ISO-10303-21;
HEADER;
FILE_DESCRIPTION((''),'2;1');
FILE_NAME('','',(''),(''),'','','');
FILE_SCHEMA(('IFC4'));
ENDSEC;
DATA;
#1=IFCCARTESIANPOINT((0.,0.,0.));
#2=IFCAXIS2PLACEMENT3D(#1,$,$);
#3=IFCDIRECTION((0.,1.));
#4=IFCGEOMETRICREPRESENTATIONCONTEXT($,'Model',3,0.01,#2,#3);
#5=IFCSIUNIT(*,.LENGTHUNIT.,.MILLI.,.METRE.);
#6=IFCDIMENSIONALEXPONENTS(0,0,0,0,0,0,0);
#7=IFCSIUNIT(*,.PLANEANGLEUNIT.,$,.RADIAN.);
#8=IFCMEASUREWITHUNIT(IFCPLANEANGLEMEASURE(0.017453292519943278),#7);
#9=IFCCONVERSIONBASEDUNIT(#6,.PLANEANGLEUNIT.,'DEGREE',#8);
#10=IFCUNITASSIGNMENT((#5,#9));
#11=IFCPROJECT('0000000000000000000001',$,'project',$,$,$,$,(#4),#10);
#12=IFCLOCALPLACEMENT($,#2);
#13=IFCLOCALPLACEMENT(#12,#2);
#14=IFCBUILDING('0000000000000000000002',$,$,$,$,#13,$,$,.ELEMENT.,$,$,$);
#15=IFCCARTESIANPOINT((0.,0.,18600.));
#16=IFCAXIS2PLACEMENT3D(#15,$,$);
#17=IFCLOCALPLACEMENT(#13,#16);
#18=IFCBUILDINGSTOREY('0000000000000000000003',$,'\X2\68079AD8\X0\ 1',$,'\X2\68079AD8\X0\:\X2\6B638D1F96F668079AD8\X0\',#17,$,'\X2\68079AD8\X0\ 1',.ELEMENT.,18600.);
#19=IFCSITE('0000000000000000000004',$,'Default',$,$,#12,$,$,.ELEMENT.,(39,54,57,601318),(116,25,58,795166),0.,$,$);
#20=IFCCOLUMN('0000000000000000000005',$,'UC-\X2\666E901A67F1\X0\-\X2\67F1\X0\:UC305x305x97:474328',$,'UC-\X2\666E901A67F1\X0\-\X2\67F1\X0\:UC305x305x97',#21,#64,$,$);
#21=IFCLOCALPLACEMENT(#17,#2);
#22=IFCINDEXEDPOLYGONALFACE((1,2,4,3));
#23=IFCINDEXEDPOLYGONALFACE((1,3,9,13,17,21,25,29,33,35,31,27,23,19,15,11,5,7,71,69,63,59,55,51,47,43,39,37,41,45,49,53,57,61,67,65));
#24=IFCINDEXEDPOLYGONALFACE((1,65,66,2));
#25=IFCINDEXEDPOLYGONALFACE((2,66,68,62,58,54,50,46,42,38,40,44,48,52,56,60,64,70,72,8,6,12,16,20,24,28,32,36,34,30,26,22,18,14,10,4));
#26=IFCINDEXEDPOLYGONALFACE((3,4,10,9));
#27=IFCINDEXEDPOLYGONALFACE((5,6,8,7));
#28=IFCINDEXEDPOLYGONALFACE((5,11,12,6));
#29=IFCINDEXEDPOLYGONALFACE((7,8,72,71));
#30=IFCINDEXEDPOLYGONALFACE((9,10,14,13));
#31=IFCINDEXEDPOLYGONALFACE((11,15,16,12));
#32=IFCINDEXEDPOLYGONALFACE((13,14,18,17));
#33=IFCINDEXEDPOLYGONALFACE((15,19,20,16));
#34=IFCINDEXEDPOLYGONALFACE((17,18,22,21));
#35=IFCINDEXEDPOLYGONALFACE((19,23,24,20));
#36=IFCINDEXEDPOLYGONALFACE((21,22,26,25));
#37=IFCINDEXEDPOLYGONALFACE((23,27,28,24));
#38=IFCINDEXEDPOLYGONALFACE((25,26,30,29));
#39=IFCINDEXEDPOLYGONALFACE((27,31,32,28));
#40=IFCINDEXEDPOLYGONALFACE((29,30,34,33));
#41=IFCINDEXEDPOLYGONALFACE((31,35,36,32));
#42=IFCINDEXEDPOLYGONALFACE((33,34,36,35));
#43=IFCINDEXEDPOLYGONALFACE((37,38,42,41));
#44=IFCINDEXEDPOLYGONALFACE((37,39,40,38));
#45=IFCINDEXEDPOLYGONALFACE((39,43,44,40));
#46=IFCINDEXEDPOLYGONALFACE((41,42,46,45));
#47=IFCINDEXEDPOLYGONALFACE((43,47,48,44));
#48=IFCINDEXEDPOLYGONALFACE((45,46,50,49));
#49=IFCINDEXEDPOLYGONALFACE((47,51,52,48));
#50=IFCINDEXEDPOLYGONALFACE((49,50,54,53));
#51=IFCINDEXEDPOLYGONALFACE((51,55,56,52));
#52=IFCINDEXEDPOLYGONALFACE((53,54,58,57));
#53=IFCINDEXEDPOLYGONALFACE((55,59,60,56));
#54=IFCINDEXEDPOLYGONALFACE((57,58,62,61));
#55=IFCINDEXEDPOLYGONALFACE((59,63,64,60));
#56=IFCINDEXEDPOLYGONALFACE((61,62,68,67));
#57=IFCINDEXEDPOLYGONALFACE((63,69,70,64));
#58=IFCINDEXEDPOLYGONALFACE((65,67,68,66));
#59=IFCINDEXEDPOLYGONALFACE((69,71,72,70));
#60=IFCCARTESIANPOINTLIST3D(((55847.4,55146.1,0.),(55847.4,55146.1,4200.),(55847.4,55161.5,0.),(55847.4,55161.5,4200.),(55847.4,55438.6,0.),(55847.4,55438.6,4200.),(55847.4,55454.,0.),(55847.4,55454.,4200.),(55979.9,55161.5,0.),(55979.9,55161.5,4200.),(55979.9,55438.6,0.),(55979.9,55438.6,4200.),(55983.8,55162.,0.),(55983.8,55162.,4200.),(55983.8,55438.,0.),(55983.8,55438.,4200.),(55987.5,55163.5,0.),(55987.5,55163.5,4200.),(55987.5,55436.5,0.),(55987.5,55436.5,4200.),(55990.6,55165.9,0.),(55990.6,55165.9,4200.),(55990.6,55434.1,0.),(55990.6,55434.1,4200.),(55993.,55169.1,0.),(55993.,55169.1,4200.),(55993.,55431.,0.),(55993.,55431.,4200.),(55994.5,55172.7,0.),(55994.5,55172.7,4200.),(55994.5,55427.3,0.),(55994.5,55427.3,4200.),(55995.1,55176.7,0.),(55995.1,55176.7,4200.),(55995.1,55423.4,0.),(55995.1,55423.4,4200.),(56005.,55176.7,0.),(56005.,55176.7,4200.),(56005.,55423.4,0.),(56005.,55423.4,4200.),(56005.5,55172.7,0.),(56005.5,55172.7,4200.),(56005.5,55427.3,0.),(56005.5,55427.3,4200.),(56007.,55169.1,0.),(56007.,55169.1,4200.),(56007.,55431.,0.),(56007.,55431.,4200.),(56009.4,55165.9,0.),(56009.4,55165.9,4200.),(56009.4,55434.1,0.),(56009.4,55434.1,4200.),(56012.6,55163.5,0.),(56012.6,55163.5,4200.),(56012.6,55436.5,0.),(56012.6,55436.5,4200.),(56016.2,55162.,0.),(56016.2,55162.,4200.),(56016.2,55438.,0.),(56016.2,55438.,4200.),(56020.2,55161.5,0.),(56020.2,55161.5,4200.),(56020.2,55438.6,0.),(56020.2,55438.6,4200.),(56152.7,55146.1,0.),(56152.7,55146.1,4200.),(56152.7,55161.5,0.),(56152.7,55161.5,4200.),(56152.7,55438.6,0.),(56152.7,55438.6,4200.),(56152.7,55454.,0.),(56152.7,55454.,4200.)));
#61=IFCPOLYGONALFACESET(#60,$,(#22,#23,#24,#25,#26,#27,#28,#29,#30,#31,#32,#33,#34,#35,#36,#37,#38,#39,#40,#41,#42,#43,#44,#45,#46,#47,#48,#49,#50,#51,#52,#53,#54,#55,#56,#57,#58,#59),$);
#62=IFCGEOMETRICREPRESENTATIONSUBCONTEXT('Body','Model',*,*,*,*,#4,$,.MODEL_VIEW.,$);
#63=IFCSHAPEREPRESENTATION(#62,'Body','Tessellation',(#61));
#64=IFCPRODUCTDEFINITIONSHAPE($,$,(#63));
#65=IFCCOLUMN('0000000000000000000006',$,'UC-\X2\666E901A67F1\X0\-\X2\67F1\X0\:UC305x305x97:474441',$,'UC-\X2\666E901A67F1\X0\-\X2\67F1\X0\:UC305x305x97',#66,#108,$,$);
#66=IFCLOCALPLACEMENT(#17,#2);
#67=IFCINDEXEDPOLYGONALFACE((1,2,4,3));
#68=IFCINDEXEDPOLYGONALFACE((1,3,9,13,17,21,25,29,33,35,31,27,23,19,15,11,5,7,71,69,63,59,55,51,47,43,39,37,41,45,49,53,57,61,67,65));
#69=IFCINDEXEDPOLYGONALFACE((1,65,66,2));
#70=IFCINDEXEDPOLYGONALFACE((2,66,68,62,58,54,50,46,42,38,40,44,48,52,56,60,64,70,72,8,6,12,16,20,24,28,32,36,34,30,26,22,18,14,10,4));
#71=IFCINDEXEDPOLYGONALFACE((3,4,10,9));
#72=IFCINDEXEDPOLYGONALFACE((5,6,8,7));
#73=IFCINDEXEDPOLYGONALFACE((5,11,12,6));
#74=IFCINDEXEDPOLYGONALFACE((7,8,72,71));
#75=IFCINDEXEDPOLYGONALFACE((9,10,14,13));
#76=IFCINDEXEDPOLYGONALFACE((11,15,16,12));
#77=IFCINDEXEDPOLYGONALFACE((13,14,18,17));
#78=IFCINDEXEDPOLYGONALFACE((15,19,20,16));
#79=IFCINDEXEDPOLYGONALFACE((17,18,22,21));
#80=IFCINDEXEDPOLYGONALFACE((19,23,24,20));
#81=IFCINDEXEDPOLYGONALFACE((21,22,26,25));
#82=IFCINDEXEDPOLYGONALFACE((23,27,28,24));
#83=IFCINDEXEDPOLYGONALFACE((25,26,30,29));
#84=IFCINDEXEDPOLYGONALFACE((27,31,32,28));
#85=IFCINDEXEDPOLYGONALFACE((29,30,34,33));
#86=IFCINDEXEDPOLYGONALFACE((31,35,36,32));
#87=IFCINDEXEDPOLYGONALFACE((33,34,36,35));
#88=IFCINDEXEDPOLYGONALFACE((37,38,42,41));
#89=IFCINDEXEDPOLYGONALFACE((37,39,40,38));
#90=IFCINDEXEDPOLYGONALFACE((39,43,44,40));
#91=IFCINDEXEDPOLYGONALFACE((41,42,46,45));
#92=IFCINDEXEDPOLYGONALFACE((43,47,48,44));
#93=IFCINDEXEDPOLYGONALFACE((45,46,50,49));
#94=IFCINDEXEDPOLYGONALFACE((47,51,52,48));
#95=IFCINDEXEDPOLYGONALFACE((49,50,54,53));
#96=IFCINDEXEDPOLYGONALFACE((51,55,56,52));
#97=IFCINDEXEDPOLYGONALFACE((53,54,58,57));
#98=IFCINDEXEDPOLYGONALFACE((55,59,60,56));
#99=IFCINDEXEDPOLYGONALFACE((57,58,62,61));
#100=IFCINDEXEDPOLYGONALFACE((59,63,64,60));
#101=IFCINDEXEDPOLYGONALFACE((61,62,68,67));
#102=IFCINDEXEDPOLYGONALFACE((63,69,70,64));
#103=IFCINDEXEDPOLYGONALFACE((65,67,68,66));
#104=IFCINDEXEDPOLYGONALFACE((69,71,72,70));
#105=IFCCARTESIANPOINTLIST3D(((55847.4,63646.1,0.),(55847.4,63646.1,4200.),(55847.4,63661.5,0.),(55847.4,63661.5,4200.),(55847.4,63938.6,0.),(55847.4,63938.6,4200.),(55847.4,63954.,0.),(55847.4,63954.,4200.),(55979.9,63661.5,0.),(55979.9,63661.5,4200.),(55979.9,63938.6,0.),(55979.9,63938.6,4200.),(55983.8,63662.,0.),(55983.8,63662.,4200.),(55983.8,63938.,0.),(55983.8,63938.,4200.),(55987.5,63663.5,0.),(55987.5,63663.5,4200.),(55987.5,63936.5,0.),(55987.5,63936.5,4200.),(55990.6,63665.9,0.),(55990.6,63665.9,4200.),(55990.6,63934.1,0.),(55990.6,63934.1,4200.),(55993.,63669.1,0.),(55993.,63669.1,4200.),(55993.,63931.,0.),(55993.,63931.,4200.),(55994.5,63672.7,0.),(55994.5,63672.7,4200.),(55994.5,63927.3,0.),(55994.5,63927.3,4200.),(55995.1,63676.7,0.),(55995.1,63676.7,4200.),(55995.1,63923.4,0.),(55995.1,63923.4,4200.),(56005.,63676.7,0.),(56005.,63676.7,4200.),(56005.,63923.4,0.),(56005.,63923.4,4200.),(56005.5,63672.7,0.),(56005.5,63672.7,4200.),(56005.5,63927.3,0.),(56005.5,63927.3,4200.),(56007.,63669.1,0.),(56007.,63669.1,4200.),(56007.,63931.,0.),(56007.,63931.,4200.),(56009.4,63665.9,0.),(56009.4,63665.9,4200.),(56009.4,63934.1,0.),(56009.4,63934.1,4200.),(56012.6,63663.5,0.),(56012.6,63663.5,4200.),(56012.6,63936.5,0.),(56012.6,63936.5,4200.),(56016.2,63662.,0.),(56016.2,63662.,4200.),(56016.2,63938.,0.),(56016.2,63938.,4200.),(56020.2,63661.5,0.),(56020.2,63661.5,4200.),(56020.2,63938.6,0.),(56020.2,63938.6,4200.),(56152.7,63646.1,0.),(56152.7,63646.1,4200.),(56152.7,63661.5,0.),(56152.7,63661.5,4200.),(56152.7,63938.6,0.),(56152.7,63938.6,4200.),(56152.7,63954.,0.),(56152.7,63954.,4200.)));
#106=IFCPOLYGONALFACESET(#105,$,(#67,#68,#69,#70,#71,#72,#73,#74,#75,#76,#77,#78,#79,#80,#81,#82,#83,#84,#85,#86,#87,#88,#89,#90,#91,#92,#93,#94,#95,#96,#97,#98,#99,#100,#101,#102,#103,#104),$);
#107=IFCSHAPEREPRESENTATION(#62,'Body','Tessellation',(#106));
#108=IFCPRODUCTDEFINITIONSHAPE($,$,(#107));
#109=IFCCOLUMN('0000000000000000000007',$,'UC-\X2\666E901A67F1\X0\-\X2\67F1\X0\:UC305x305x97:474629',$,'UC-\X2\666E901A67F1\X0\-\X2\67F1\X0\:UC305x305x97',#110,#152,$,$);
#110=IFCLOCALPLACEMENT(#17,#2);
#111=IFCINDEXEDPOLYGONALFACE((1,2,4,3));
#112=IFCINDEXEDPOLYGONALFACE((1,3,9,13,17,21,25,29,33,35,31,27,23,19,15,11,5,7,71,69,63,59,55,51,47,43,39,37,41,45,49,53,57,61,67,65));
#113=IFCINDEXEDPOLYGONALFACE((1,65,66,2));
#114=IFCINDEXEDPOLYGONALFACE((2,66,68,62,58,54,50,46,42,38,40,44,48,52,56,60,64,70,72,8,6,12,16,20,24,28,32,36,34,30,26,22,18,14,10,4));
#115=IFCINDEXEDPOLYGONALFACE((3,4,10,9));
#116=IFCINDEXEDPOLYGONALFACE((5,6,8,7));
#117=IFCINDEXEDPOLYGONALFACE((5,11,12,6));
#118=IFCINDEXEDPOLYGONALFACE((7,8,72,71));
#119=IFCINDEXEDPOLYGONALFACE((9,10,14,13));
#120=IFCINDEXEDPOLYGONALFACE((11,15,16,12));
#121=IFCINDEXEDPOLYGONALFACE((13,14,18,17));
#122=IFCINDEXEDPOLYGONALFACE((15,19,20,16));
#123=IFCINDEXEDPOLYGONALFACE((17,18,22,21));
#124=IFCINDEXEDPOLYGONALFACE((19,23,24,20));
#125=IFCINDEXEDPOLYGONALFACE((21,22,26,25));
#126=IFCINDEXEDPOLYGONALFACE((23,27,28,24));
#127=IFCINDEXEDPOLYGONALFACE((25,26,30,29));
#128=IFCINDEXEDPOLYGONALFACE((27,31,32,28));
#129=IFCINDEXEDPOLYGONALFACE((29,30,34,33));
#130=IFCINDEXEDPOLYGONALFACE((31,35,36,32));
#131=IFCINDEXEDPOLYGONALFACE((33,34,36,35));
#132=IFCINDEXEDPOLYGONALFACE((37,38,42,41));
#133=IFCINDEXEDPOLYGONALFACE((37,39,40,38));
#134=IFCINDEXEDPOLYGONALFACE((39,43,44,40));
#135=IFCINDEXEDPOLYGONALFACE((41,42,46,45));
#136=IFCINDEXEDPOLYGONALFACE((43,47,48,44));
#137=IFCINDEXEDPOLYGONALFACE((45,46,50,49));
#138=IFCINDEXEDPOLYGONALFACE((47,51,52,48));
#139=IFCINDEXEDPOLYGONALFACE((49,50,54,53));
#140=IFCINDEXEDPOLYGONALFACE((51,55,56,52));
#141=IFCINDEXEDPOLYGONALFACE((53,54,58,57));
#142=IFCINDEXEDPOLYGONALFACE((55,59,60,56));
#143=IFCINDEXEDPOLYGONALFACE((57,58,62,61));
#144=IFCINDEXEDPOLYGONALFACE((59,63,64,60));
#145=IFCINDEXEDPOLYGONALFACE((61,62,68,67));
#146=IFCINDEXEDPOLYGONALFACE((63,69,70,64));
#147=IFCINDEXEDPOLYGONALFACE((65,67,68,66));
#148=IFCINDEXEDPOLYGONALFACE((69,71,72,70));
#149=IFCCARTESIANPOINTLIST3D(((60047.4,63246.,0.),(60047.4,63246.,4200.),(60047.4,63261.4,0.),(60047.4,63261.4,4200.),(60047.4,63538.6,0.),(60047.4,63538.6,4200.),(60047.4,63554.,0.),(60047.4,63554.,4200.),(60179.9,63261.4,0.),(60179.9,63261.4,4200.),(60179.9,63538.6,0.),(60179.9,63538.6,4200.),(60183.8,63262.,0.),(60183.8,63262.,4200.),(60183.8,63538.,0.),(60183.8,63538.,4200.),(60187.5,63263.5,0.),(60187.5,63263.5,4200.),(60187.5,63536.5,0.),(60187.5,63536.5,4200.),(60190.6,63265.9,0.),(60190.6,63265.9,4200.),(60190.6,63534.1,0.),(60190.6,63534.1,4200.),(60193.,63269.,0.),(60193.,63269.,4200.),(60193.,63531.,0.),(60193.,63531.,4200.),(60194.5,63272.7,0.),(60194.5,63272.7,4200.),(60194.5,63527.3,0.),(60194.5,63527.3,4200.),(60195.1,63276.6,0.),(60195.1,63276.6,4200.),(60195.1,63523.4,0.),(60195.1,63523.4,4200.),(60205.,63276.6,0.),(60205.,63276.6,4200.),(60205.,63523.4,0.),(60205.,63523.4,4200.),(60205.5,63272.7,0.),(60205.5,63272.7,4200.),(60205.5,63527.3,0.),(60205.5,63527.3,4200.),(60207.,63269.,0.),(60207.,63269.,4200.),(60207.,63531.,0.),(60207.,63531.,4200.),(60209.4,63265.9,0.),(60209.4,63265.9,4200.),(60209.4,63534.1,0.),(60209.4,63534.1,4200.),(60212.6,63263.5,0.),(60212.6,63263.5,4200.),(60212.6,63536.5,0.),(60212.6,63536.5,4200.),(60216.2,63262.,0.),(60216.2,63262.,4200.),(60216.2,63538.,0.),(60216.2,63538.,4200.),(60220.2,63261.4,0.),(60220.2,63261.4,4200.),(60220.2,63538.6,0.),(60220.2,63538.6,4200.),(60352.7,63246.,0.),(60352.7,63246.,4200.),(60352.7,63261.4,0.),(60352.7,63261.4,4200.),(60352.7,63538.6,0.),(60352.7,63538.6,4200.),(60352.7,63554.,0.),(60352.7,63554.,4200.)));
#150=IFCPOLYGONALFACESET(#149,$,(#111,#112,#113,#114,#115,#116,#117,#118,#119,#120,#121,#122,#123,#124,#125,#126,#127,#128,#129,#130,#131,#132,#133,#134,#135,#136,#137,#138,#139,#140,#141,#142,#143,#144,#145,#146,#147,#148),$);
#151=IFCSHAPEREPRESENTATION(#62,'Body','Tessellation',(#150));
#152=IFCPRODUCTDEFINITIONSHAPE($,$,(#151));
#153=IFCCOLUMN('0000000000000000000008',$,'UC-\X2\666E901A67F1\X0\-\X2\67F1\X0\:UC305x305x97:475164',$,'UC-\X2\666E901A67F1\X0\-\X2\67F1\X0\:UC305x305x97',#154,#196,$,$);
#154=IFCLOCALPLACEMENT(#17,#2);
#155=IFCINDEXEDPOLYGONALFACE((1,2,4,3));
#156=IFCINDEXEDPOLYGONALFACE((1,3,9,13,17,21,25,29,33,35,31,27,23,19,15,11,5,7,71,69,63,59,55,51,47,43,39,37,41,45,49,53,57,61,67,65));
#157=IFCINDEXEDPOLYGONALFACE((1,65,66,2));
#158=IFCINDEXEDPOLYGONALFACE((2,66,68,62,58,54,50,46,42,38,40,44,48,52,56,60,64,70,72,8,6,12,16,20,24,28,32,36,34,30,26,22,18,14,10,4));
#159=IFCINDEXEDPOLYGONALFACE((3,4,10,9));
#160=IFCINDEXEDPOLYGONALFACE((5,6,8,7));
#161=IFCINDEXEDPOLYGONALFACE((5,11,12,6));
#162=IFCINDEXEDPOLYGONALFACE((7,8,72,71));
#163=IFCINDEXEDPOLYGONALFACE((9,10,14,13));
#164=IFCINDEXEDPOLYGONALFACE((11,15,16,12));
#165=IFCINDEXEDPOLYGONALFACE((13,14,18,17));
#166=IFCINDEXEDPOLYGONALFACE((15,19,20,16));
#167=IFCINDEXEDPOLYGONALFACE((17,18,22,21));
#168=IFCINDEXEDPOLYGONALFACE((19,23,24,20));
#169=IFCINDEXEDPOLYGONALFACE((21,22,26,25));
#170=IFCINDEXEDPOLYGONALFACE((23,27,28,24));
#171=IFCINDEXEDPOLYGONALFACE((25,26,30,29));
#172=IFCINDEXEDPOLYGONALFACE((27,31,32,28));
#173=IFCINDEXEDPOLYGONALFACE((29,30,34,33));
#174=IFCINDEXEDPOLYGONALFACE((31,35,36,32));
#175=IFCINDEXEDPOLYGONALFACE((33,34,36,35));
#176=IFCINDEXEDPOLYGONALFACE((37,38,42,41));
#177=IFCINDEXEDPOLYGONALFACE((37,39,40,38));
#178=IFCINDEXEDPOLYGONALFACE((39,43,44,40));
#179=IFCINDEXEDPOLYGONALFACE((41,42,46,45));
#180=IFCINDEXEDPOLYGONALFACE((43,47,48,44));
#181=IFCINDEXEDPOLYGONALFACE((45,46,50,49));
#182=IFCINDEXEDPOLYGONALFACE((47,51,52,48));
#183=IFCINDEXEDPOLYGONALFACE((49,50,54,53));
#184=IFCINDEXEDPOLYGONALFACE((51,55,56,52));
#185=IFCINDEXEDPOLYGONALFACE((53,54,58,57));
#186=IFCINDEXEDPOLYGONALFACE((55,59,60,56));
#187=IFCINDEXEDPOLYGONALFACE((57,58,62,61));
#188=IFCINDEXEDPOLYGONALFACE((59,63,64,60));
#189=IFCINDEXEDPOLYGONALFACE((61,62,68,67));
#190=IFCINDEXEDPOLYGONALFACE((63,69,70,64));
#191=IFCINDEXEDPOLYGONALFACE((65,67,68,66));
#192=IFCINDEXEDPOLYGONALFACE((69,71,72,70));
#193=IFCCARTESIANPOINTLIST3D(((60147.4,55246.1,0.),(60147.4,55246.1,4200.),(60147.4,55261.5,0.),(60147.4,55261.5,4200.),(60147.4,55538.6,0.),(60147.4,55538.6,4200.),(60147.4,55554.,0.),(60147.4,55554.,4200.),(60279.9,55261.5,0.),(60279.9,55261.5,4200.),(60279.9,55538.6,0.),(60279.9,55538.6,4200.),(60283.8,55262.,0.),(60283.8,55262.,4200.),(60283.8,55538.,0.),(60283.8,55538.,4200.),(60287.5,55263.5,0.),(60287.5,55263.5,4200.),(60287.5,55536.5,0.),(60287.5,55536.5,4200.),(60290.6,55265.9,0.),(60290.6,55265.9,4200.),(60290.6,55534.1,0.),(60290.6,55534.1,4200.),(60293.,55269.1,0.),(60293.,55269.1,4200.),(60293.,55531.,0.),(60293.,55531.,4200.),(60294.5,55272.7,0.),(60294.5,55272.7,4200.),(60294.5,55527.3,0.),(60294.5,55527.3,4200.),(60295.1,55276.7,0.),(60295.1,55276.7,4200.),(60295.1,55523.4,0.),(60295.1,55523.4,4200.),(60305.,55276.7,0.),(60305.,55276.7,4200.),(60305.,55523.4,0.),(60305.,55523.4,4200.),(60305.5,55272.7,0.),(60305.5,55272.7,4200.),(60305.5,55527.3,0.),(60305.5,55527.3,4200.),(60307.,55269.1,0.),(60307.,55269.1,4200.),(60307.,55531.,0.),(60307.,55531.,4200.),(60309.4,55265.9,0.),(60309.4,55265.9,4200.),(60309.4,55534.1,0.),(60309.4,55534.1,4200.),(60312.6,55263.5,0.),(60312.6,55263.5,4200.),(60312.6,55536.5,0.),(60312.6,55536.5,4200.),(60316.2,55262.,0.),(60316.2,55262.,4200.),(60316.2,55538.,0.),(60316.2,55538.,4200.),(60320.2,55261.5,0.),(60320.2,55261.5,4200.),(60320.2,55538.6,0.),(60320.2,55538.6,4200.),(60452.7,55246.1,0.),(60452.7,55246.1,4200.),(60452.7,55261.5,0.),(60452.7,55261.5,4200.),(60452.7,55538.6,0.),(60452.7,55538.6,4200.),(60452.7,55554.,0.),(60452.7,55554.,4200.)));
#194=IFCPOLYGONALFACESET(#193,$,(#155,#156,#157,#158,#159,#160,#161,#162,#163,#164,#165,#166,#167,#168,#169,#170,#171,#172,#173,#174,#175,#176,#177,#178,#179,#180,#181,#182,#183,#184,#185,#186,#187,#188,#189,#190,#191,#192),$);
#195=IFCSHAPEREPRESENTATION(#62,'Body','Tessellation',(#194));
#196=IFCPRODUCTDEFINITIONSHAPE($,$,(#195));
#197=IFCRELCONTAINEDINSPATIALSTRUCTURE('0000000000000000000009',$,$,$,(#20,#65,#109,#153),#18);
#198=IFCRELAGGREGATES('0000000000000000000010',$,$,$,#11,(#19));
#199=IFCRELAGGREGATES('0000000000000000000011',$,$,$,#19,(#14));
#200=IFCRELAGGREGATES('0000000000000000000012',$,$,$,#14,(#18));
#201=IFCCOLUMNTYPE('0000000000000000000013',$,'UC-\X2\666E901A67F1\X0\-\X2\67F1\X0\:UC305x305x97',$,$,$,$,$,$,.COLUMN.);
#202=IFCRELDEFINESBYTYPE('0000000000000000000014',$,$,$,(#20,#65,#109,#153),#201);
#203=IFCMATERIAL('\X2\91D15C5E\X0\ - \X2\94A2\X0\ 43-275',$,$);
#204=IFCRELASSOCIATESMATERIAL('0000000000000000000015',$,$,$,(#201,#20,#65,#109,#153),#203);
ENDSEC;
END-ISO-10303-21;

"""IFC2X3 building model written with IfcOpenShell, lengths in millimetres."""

from ifc_helpers import new_model, entity, si_unit, converted_unit, direction, frame, origin, origin_2d_with_axis, place, context, subcontext, project, spatial, i_section, extrude, source, transform, mapped, material, type_object, type_shapes, element, save


model = new_model("IFC2X3")

# Units and contexts
model_context = context("Model", 3, precision=0.01, world=origin(), true_north=direction((0.0, 1.0)))
body_context = subcontext(model_context, "Body", "Model", "MODEL_VIEW")
ifc_project = project(units=[si_unit("LENGTHUNIT", "METRE", prefix="MILLI"), converted_unit("PLANEANGLEUNIT", "DEGREE", entity("IfcPlaneAngleMeasure", 0.017453292519943278), si_unit("PLANEANGLEUNIT", "RADIAN"), dimensions=[0, 0, 0, 0, 0, 0, 0])], contexts=[model_context])

# Site, building, storey
site_placement = place(None, origin())
site = spatial("IfcSite", under=ifc_project, at=site_placement, Name="Default", CompositionType="ELEMENT", RefLatitude=(39, 54, 57, 601318), RefLongitude=(116, 25, 58, 795166), RefElevation=0.0)
building_placement = place(site_placement, origin())
building = spatial("IfcBuilding", under=site, at=building_placement, CompositionType="ELEMENT")
storey_placement = place(building_placement, frame((0.0, 0.0, 18600.0)))
storey = spatial("IfcBuildingStorey", under=building, at=storey_placement, Name="标高 1", ObjectType="标高:正负零标高", LongName="标高 1", CompositionType="ELEMENT", Elevation=18600.0)

# Columns
ifc_material_1 = material(Name="金属 - 钢 43-275")
column_type = type_object("IfcColumnType", Name="UC-普通柱-柱:UC305x305x97", PredefinedType="COLUMN", material=ifc_material_1)
shared_shape_1 = source(origin(), body_context, "Body", "SweptSolid", [
    extrude(i_section(OverallWidth=305.3, OverallDepth=307.9, WebThickness=9.9, FlangeThickness=15.4, FilletRadius=15.2, at=origin_2d_with_axis()), frame((0.0, 0.0, 18600.0), z_axis=(0.0, 0.0, 1.0), x_axis=(-1.0, 0.0, 0.0)), (0.0, 0.0, 1.0), 4200.0),
])
type_shapes(column_type, [shared_shape_1])
for number, where, name in (
    (1, (56000.0, 55300.0, -18600.0), "UC-普通柱-柱:UC305x305x97:474328"),
    (2, (56000.0, 63800.0, -18600.0), "UC-普通柱-柱:UC305x305x97:474441"),
    (3, (60200.0, 63400.0, -18600.0), "UC-普通柱-柱:UC305x305x97:474629"),
    (4, (60300.0, 55400.0, -18600.0), "UC-普通柱-柱:UC305x305x97:475164"),
):
    element("IfcColumn", number, at=place(storey_placement, frame(where)), inside=storey, type_object=column_type, material=ifc_material_1, Name=name, ObjectType="UC-普通柱-柱:UC305x305x97", context=body_context, shape_type="MappedRepresentation", body=[
        mapped(shared_shape_1, transform((0.0, 0.0, 0.0), scale=1.0)),
    ])

save(model, "model.ifc")
